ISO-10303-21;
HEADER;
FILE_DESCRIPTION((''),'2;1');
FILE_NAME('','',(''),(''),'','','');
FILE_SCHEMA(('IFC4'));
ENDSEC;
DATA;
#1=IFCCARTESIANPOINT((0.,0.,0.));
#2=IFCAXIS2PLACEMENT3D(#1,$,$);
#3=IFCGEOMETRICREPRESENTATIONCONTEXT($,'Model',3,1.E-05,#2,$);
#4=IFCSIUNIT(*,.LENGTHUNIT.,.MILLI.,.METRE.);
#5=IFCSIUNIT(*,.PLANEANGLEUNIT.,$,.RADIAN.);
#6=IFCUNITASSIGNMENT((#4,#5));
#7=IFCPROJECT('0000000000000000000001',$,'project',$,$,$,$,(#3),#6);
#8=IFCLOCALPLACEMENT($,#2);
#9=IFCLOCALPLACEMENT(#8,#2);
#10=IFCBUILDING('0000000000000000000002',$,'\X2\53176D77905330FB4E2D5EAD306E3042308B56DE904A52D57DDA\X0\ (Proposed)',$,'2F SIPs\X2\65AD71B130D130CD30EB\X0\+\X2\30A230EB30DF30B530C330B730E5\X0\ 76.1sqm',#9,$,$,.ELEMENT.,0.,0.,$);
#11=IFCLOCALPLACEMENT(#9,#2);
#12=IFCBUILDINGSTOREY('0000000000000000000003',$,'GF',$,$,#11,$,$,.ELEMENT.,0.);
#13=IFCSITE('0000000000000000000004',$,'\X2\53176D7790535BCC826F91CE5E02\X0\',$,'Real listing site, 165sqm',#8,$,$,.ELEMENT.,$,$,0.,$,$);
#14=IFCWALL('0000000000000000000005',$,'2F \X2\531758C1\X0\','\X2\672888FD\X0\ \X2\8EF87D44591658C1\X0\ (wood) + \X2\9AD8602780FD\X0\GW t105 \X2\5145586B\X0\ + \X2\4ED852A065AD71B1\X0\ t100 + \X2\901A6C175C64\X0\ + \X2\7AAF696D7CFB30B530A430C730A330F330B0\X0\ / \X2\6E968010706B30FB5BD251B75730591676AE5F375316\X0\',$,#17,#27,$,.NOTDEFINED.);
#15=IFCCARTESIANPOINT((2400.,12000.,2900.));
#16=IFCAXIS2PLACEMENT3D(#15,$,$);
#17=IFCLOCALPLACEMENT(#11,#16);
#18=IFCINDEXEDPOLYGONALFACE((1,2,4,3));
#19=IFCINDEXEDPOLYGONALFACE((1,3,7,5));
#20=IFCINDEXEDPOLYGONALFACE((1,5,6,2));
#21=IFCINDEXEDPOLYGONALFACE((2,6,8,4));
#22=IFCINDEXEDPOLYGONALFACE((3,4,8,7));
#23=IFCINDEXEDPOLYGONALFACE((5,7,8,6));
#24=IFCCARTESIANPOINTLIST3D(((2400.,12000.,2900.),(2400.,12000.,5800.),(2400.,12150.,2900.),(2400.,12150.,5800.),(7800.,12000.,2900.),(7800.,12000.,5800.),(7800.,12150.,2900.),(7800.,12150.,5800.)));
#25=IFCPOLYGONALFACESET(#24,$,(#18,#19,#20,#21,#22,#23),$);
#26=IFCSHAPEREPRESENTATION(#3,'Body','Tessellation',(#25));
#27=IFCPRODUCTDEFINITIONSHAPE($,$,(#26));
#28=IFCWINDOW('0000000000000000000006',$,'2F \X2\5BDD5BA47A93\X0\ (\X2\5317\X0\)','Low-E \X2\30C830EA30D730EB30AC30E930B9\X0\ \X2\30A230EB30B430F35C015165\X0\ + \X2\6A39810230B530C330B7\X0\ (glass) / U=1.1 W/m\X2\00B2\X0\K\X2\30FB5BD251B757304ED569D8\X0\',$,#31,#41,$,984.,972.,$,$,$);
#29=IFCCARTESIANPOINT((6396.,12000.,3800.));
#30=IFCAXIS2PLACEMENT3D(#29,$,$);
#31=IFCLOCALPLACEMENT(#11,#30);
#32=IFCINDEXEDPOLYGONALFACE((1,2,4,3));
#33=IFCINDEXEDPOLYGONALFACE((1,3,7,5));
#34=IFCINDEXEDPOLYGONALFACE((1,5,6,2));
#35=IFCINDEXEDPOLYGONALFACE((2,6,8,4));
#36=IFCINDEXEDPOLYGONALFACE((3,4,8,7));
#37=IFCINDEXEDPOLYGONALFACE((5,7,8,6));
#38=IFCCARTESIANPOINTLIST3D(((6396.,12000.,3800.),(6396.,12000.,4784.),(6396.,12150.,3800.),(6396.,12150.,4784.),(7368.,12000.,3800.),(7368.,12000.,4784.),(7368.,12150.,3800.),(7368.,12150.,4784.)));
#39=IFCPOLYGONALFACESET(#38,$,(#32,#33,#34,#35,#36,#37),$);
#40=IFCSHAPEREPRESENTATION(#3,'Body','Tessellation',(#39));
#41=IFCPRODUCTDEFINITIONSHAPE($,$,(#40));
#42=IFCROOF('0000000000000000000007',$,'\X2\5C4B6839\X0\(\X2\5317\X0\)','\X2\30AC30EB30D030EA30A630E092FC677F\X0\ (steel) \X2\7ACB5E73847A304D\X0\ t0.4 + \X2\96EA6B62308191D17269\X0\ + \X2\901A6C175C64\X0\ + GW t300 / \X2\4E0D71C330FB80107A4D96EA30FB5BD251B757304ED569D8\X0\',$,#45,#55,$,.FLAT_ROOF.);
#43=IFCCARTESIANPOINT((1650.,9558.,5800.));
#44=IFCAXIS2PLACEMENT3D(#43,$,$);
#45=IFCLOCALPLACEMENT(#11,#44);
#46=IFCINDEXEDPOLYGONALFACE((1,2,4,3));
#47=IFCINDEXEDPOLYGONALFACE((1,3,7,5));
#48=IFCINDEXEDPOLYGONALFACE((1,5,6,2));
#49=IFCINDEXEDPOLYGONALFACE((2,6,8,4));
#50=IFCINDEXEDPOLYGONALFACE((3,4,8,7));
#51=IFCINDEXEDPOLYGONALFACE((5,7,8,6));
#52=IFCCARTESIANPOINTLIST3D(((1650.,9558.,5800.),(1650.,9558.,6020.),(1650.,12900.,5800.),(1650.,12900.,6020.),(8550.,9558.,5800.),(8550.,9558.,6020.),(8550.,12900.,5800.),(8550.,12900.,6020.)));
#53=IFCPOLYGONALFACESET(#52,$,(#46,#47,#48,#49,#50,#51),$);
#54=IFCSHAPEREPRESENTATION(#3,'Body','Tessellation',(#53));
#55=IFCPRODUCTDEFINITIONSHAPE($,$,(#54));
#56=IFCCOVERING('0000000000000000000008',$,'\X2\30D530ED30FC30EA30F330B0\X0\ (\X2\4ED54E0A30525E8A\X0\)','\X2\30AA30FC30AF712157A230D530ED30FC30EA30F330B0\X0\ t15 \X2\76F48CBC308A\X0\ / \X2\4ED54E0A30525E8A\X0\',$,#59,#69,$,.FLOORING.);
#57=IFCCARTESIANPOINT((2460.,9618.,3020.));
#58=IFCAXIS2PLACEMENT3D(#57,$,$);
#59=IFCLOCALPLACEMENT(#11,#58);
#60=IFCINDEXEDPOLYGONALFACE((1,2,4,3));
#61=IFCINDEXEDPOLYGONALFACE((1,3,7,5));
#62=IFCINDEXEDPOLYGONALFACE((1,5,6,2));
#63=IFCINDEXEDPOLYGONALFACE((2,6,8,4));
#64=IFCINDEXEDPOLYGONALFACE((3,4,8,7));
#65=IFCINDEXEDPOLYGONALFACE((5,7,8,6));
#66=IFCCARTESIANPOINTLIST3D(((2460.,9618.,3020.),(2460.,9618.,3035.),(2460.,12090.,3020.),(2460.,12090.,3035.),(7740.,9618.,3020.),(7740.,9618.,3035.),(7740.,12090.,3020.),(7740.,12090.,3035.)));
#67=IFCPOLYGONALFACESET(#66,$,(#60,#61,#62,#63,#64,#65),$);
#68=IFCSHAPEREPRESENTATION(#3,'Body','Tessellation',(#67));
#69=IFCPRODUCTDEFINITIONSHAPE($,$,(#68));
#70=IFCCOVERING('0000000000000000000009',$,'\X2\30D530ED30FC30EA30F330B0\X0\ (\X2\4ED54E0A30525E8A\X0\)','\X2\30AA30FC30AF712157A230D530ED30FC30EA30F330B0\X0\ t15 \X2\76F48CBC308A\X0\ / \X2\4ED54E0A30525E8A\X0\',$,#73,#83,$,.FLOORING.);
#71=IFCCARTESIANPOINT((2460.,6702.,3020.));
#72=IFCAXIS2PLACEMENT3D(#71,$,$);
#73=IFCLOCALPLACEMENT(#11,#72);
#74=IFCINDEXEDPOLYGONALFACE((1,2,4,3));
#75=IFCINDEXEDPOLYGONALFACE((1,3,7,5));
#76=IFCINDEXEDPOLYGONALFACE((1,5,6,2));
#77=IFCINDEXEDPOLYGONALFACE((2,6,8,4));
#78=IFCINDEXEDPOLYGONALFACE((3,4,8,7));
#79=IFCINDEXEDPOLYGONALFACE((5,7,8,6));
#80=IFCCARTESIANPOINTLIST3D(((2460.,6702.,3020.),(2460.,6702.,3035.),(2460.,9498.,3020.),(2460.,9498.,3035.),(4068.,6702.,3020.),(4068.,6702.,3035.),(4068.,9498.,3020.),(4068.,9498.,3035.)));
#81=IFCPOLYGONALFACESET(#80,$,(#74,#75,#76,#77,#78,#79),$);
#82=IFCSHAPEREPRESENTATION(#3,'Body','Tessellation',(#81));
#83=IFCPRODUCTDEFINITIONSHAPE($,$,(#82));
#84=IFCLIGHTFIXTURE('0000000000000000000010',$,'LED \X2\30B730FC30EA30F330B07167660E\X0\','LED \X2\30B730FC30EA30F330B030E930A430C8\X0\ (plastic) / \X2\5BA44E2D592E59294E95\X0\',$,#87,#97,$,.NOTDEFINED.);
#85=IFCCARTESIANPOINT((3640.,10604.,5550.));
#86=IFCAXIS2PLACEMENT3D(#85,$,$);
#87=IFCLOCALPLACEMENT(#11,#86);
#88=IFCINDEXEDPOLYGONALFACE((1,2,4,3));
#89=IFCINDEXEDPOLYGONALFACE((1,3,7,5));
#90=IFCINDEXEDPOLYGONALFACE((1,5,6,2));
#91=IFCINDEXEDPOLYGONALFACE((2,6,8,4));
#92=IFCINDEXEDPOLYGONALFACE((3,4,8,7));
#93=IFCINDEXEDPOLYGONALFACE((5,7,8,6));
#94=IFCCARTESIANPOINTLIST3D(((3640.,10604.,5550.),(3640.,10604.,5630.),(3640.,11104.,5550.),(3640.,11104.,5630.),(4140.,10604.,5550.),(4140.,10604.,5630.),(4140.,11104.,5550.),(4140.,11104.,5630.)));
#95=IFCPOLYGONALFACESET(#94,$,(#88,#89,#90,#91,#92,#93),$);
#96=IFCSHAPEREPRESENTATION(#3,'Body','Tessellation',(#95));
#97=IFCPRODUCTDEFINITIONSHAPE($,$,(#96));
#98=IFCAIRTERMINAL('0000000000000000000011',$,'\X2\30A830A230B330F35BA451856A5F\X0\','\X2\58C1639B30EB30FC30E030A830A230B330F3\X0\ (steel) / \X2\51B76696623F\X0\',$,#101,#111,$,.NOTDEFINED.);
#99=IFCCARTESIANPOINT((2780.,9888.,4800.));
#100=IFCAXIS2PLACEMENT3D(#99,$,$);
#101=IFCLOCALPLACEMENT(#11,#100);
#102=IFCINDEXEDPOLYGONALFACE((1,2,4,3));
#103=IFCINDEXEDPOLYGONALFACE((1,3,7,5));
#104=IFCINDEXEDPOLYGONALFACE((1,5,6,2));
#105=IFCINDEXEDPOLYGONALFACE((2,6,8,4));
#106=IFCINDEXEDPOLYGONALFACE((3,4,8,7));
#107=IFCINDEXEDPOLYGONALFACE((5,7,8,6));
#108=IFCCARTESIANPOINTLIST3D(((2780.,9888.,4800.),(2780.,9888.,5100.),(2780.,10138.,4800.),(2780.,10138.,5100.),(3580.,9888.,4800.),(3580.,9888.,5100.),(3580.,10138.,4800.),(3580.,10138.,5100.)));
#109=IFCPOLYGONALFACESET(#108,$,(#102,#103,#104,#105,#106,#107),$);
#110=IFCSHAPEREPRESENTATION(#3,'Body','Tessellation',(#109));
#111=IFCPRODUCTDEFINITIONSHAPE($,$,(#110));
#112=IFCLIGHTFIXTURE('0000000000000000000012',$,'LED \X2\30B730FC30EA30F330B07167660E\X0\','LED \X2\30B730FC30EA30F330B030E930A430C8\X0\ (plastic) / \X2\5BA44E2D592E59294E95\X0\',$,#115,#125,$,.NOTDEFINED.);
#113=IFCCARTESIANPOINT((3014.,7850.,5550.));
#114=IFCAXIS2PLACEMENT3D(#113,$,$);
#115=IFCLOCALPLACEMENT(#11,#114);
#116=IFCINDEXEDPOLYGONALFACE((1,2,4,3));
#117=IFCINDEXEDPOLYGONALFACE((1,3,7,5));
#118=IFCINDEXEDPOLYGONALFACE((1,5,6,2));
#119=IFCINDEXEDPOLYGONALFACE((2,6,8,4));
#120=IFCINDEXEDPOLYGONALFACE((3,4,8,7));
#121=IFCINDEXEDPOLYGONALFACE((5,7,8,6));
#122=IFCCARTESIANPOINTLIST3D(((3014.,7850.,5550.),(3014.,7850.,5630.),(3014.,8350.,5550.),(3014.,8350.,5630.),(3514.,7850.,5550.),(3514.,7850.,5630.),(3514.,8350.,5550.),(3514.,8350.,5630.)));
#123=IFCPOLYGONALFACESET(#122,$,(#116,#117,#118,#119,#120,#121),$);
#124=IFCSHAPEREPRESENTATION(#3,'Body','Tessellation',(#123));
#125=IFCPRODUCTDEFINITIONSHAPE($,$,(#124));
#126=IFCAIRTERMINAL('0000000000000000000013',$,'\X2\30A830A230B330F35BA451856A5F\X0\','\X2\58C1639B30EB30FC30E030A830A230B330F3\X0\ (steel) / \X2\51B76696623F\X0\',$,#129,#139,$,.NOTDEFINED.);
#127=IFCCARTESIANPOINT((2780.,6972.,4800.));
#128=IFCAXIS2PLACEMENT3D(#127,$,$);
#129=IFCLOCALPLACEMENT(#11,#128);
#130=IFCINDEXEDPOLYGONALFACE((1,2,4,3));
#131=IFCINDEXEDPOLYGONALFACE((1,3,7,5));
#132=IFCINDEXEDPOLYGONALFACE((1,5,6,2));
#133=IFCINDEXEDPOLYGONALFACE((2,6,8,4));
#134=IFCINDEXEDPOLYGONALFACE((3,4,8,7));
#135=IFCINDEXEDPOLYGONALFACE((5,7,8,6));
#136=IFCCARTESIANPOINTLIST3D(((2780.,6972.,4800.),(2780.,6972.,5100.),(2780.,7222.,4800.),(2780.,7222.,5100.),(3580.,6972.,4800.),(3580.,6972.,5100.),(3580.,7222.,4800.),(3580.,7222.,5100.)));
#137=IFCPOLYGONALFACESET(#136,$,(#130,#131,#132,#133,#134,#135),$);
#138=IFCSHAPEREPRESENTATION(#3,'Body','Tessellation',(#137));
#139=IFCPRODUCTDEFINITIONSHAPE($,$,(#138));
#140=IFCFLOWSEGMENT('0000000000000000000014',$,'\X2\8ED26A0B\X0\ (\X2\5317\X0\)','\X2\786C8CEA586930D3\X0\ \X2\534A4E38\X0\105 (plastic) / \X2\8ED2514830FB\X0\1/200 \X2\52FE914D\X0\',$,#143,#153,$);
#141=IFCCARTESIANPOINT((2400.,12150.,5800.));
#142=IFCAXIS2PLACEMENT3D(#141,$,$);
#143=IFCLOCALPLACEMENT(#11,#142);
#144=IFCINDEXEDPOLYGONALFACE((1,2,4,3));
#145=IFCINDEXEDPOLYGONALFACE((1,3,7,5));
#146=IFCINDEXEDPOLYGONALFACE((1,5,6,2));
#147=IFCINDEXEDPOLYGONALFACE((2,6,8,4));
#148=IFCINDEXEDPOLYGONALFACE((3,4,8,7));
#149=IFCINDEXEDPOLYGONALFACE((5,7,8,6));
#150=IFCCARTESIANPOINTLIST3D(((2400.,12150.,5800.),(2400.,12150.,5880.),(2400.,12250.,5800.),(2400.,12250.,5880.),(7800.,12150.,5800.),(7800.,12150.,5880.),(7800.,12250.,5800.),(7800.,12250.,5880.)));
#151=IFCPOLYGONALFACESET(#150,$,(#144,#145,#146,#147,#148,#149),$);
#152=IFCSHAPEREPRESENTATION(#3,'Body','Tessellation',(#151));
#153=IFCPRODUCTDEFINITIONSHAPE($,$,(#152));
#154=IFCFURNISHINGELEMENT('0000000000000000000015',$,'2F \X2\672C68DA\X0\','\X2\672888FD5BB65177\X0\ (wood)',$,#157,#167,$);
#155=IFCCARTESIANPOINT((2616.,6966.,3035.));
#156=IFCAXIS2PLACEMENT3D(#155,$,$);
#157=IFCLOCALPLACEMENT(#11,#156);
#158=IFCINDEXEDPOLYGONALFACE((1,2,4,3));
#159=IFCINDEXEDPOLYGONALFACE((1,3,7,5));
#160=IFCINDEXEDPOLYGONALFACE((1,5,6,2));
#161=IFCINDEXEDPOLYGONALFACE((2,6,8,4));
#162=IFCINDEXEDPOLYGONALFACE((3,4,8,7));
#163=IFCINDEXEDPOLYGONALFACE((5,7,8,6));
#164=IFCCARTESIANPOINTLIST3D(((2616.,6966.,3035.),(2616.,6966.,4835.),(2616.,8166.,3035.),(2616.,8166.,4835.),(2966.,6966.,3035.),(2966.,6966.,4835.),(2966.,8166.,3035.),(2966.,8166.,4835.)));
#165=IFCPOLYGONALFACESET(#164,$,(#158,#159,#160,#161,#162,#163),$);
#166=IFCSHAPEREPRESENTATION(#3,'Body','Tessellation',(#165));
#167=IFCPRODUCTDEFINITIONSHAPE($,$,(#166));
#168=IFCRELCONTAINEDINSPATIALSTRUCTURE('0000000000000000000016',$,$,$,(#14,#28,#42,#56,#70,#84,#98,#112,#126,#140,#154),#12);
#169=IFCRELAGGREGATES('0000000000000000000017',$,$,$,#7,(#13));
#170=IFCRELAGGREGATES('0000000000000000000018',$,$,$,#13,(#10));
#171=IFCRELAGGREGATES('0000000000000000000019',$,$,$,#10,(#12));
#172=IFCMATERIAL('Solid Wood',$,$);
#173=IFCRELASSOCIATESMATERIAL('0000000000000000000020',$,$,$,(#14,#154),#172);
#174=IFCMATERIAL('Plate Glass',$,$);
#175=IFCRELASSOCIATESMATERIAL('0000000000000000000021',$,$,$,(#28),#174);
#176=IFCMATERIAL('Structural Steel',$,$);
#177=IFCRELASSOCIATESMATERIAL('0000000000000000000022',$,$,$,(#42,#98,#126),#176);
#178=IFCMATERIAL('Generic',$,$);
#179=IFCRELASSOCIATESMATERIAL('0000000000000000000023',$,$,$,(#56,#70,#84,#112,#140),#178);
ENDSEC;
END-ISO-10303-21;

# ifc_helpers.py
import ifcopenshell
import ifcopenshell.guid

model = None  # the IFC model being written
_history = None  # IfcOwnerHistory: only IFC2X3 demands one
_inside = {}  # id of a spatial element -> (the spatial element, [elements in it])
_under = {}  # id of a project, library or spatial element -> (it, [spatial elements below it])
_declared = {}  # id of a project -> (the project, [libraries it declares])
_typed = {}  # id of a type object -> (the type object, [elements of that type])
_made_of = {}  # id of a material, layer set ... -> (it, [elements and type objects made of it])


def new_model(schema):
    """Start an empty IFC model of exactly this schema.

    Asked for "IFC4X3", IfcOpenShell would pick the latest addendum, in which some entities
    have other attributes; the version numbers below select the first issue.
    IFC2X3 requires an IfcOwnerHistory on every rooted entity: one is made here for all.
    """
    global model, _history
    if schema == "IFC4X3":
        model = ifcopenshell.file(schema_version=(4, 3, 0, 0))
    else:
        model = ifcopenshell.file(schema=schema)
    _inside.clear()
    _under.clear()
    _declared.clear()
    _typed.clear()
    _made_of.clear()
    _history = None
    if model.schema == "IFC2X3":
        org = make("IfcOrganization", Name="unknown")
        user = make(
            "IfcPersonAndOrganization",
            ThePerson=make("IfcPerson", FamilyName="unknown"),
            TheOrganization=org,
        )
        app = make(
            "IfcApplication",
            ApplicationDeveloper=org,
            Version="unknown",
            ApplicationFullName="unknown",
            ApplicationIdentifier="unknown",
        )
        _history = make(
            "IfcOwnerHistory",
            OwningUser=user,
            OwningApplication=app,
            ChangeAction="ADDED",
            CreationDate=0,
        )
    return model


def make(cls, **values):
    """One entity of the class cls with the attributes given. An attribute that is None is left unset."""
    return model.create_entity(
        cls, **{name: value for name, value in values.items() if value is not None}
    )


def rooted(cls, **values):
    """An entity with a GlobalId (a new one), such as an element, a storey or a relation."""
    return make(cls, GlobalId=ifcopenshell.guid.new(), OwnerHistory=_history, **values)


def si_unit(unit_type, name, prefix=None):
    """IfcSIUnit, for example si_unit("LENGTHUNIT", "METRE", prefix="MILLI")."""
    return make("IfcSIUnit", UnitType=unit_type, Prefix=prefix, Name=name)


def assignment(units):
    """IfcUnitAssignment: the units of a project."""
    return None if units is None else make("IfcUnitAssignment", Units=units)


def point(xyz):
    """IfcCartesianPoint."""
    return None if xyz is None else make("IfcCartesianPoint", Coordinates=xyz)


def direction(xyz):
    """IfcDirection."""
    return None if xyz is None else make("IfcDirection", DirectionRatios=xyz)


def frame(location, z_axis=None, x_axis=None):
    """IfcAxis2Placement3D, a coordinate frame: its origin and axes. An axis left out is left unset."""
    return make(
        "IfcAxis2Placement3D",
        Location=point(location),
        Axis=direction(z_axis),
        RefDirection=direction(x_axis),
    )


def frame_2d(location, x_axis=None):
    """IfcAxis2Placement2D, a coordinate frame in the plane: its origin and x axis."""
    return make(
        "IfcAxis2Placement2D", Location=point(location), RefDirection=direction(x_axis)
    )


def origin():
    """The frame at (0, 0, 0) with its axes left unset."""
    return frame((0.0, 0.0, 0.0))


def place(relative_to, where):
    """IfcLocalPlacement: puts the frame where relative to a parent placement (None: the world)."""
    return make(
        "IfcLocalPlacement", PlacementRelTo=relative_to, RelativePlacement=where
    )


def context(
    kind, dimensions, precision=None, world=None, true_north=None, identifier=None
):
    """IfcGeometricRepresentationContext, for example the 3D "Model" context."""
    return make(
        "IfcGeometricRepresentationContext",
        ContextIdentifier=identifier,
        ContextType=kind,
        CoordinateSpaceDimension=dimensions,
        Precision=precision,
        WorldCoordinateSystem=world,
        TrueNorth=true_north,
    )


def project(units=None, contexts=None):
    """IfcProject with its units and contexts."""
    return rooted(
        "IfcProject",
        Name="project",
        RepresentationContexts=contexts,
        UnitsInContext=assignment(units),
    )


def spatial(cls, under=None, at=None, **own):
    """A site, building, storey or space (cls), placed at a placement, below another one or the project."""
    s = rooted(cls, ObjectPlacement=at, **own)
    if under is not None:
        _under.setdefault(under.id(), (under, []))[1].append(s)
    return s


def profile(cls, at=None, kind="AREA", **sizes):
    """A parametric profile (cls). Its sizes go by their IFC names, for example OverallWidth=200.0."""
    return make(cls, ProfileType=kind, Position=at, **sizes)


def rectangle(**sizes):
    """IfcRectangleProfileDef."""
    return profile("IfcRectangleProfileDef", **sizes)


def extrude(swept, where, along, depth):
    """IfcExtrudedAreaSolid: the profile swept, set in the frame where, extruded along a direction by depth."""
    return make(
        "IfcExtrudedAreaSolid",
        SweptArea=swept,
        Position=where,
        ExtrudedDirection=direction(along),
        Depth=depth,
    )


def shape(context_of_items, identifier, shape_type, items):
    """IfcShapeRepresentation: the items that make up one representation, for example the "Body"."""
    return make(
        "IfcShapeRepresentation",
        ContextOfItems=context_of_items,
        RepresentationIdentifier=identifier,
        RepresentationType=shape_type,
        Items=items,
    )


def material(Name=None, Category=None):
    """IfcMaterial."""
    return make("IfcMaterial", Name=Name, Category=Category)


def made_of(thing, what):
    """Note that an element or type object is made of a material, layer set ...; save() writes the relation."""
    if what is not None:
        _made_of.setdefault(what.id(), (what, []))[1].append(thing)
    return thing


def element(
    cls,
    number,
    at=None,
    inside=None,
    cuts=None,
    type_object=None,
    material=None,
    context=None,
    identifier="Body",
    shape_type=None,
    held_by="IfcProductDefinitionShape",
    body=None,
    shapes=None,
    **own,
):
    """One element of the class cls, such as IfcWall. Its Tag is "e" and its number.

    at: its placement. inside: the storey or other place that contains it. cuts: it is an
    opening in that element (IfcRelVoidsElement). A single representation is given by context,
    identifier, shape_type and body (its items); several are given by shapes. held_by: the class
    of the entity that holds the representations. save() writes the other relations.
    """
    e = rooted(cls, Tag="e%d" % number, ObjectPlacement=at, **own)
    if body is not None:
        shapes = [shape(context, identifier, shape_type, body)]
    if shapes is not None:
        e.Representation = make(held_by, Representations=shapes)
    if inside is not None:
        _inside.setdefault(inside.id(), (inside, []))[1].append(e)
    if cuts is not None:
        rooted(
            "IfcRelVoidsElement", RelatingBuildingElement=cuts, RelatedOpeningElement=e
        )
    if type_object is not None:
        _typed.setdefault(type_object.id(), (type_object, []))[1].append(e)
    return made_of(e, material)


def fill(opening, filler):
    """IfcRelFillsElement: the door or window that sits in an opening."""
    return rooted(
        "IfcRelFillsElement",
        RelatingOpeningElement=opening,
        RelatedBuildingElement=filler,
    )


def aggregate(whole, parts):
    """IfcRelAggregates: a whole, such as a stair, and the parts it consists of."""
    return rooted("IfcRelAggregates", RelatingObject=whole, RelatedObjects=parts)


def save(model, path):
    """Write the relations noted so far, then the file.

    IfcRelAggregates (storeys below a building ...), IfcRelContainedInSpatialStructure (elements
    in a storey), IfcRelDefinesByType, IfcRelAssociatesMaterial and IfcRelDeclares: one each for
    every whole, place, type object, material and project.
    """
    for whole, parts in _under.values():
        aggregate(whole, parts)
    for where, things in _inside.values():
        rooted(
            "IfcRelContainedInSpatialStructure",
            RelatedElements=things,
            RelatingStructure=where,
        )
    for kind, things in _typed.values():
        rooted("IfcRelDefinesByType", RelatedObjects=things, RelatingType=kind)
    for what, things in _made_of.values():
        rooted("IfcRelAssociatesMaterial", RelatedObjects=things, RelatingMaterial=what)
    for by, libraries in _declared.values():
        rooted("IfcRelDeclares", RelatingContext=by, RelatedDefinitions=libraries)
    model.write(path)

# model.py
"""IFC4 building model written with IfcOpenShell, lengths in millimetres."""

from ifc_helpers import new_model, si_unit, frame, frame_2d, origin, place, context, project, spatial, rectangle, extrude, material, element, fill, save


model = new_model("IFC4")

# Units and contexts
model_context = context("Model", 3, precision=1e-05, world=origin())
ifc_project = project(units=[si_unit("LENGTHUNIT", "METRE", prefix="MILLI"), si_unit("PLANEANGLEUNIT", "RADIAN")], contexts=[model_context])

# Site, building, storey
site_placement = place(None, origin())
site = spatial("IfcSite", under=ifc_project, at=site_placement, Name="北海道富良野市", ObjectType="Real listing site, 165sqm", CompositionType="ELEMENT", RefElevation=0.0)
building_placement = place(site_placement, origin())
building = spatial("IfcBuilding", under=site, at=building_placement, Name="北海道・中庭のある回遊動線 (Proposed)", ObjectType="2F SIPs断熱パネル+アルミサッシュ 76.1sqm", CompositionType="ELEMENT", ElevationOfRefHeight=0.0, ElevationOfTerrain=0.0)
storey_placement = place(building_placement, origin())
storey = spatial("IfcBuildingStorey", under=building, at=storey_placement, Name="GF", CompositionType="ELEMENT", Elevation=0.0)

# Shared definitions
ifc_material_1 = material(Name="Solid Wood")

# Wall, opening, window
wall_placement = place(storey_placement, frame((2400.0, 12000.0, 2900.0)))
wall = element("IfcWall", 1, at=wall_placement, inside=storey, material=ifc_material_1, Name="2F 北壁", Description="木製 軸組外壁 (wood) + 高性能GW t105 充填 + 付加断熱 t100 + 通気層 + 窯業系サイディング / 準耐火・寒冷地外皮強化", PredefinedType="NOTDEFINED", context=model_context, shape_type="SweptSolid", body=[
    extrude(rectangle(XDim=5400.0, YDim=150.0, at=frame_2d((2700.0, 75.0))), frame((2400.0, 12000.0, 2900.0)), (0.0, 0.0, 1.0), 2900.0),
])
opening_placement = place(storey_placement, frame((6396.0, 12000.0, 3800.0)))
opening = element("IfcOpeningElement", 2, at=opening_placement, cuts=wall, PredefinedType="NOTDEFINED", context=model_context, shape_type="SweptSolid", body=[
    extrude(rectangle(XDim=972.0, YDim=150.0, at=frame_2d((486.0, 75.0))), frame((6396.0, 12000.0, 3800.0)), (0.0, 0.0, 1.0), 984.0),
])
ifc_material_2 = material(Name="Plate Glass")
window_placement = place(storey_placement, frame((6396.0, 12000.0, 3800.0)))
window = element("IfcWindow", 3, at=window_placement, inside=storey, material=ifc_material_2, Name="2F 寝室窓 (北)", Description="Low-E トリプルガラス アルゴン封入 + 樹脂サッシ (glass) / U=1.1 W/m²K・寒冷地仕様", OverallHeight=984.0, OverallWidth=972.0, context=model_context, shape_type="SweptSolid", body=[
    extrude(rectangle(XDim=972.0, YDim=150.0, at=frame_2d((486.0, 75.0))), frame((6396.0, 12000.0, 3800.0)), (0.0, 0.0, 1.0), 984.0),
])
fill(opening, window)

# Roof
ifc_material_3 = material(Name="Structural Steel")
for number, where, name in (
    (4, (1650.0, 9558.0, 5800.0), "屋根(北)"),
):
    element("IfcRoof", number, at=place(storey_placement, frame(where)), inside=storey, material=ifc_material_3, Name=name, Description="ガルバリウム鋼板 (steel) 立平葺き t0.4 + 雪止め金物 + 通気層 + GW t300 / 不燃・耐積雪・寒冷地仕様", PredefinedType="FLAT_ROOF", context=model_context, shape_type="SweptSolid", body=[
        extrude(rectangle(XDim=6900.0, YDim=3342.0, at=frame_2d((3450.0, 1671.0))), frame((1650.0, 9558.0, 5800.0)), (0.0, 0.0, 1.0), 220.0),
    ])

# Coverings
ifc_material_4 = material(Name="Generic")
covering_1_placement = place(storey_placement, frame((2460.0, 9618.0, 3020.0)))
element("IfcCovering", 5, at=covering_1_placement, inside=storey, material=ifc_material_4, Name="フローリング (仕上げ床)", Description="オーク無垢フローリング t15 直貼り / 仕上げ床", PredefinedType="FLOORING", context=model_context, shape_type="SweptSolid", body=[
    extrude(rectangle(XDim=5280.0, YDim=2472.0, at=frame_2d((2640.0, 1236.0))), frame((2460.0, 9618.0, 3020.0)), (0.0, 0.0, 1.0), 15.0),
])
covering_2_placement = place(storey_placement, frame((2460.0, 6702.0, 3020.0)))
element("IfcCovering", 6, at=covering_2_placement, inside=storey, material=ifc_material_4, Name="フローリング (仕上げ床)", Description="オーク無垢フローリング t15 直貼り / 仕上げ床", PredefinedType="FLOORING", context=model_context, shape_type="SweptSolid", body=[
    extrude(rectangle(XDim=1608.0, YDim=2796.0, at=frame_2d((804.0, 1398.0))), frame((2460.0, 6702.0, 3020.0)), (0.0, 0.0, 1.0), 15.0),
])

# Light fixture
light_fixture_1_placement = place(storey_placement, frame((3640.0, 10604.0, 5550.0)))
element("IfcLightFixture", 7, at=light_fixture_1_placement, inside=storey, material=ifc_material_4, Name="LED シーリング照明", Description="LED シーリングライト (plastic) / 室中央天井", PredefinedType="NOTDEFINED", context=model_context, shape_type="SweptSolid", body=[
    extrude(rectangle(XDim=500.0, YDim=500.0, at=frame_2d((250.0, 250.0))), frame((3640.0, 10604.0, 5550.0)), (0.0, 0.0, 1.0), 80.0),
])

# Air terminal
air_terminal_1_placement = place(storey_placement, frame((2780.0, 9888.0, 4800.0)))
element("IfcAirTerminal", 8, at=air_terminal_1_placement, inside=storey, material=ifc_material_3, Name="エアコン室内機", Description="壁掛ルームエアコン (steel) / 冷暖房", PredefinedType="NOTDEFINED", context=model_context, shape_type="SweptSolid", body=[
    extrude(rectangle(XDim=800.0, YDim=250.0, at=frame_2d((400.0, 125.0))), frame((2780.0, 9888.0, 4800.0)), (0.0, 0.0, 1.0), 300.0),
])

# Light fixture
light_fixture_2_placement = place(storey_placement, frame((3014.0, 7850.0, 5550.0)))
element("IfcLightFixture", 9, at=light_fixture_2_placement, inside=storey, material=ifc_material_4, Name="LED シーリング照明", Description="LED シーリングライト (plastic) / 室中央天井", PredefinedType="NOTDEFINED", context=model_context, shape_type="SweptSolid", body=[
    extrude(rectangle(XDim=500.0, YDim=500.0, at=frame_2d((250.0, 250.0))), frame((3014.0, 7850.0, 5550.0)), (0.0, 0.0, 1.0), 80.0),
])

# Air terminal
air_terminal_2_placement = place(storey_placement, frame((2780.0, 6972.0, 4800.0)))
element("IfcAirTerminal", 10, at=air_terminal_2_placement, inside=storey, material=ifc_material_3, Name="エアコン室内機", Description="壁掛ルームエアコン (steel) / 冷暖房", PredefinedType="NOTDEFINED", context=model_context, shape_type="SweptSolid", body=[
    extrude(rectangle(XDim=800.0, YDim=250.0, at=frame_2d((400.0, 125.0))), frame((2780.0, 6972.0, 4800.0)), (0.0, 0.0, 1.0), 300.0),
])

# Flow segment
flow_segment_placement = place(storey_placement, frame((2400.0, 12150.0, 5800.0)))
element("IfcFlowSegment", 11, at=flow_segment_placement, inside=storey, material=ifc_material_4, Name="軒樋 (北)", Description="硬質塩ビ 半丸105 (plastic) / 軒先・1/200 勾配", context=model_context, shape_type="SweptSolid", body=[
    extrude(rectangle(XDim=5400.0, YDim=100.0, at=frame_2d((2700.0, 50.0))), frame((2400.0, 12150.0, 5800.0)), (0.0, 0.0, 1.0), 80.0),
])

# Furnishing element
furnishing_placement = place(storey_placement, frame((2616.0, 6966.0, 3035.0)))
element("IfcFurnishingElement", 12, at=furnishing_placement, inside=storey, material=ifc_material_1, Name="2F 本棚", Description="木製家具 (wood)", context=model_context, shape_type="SweptSolid", body=[
    extrude(rectangle(XDim=350.0, YDim=1200.0, at=frame_2d((175.0, 600.0))), frame((2616.0, 6966.0, 3035.0)), (0.0, 0.0, 1.0), 1800.0),
])

save(model, "model.ifc")
